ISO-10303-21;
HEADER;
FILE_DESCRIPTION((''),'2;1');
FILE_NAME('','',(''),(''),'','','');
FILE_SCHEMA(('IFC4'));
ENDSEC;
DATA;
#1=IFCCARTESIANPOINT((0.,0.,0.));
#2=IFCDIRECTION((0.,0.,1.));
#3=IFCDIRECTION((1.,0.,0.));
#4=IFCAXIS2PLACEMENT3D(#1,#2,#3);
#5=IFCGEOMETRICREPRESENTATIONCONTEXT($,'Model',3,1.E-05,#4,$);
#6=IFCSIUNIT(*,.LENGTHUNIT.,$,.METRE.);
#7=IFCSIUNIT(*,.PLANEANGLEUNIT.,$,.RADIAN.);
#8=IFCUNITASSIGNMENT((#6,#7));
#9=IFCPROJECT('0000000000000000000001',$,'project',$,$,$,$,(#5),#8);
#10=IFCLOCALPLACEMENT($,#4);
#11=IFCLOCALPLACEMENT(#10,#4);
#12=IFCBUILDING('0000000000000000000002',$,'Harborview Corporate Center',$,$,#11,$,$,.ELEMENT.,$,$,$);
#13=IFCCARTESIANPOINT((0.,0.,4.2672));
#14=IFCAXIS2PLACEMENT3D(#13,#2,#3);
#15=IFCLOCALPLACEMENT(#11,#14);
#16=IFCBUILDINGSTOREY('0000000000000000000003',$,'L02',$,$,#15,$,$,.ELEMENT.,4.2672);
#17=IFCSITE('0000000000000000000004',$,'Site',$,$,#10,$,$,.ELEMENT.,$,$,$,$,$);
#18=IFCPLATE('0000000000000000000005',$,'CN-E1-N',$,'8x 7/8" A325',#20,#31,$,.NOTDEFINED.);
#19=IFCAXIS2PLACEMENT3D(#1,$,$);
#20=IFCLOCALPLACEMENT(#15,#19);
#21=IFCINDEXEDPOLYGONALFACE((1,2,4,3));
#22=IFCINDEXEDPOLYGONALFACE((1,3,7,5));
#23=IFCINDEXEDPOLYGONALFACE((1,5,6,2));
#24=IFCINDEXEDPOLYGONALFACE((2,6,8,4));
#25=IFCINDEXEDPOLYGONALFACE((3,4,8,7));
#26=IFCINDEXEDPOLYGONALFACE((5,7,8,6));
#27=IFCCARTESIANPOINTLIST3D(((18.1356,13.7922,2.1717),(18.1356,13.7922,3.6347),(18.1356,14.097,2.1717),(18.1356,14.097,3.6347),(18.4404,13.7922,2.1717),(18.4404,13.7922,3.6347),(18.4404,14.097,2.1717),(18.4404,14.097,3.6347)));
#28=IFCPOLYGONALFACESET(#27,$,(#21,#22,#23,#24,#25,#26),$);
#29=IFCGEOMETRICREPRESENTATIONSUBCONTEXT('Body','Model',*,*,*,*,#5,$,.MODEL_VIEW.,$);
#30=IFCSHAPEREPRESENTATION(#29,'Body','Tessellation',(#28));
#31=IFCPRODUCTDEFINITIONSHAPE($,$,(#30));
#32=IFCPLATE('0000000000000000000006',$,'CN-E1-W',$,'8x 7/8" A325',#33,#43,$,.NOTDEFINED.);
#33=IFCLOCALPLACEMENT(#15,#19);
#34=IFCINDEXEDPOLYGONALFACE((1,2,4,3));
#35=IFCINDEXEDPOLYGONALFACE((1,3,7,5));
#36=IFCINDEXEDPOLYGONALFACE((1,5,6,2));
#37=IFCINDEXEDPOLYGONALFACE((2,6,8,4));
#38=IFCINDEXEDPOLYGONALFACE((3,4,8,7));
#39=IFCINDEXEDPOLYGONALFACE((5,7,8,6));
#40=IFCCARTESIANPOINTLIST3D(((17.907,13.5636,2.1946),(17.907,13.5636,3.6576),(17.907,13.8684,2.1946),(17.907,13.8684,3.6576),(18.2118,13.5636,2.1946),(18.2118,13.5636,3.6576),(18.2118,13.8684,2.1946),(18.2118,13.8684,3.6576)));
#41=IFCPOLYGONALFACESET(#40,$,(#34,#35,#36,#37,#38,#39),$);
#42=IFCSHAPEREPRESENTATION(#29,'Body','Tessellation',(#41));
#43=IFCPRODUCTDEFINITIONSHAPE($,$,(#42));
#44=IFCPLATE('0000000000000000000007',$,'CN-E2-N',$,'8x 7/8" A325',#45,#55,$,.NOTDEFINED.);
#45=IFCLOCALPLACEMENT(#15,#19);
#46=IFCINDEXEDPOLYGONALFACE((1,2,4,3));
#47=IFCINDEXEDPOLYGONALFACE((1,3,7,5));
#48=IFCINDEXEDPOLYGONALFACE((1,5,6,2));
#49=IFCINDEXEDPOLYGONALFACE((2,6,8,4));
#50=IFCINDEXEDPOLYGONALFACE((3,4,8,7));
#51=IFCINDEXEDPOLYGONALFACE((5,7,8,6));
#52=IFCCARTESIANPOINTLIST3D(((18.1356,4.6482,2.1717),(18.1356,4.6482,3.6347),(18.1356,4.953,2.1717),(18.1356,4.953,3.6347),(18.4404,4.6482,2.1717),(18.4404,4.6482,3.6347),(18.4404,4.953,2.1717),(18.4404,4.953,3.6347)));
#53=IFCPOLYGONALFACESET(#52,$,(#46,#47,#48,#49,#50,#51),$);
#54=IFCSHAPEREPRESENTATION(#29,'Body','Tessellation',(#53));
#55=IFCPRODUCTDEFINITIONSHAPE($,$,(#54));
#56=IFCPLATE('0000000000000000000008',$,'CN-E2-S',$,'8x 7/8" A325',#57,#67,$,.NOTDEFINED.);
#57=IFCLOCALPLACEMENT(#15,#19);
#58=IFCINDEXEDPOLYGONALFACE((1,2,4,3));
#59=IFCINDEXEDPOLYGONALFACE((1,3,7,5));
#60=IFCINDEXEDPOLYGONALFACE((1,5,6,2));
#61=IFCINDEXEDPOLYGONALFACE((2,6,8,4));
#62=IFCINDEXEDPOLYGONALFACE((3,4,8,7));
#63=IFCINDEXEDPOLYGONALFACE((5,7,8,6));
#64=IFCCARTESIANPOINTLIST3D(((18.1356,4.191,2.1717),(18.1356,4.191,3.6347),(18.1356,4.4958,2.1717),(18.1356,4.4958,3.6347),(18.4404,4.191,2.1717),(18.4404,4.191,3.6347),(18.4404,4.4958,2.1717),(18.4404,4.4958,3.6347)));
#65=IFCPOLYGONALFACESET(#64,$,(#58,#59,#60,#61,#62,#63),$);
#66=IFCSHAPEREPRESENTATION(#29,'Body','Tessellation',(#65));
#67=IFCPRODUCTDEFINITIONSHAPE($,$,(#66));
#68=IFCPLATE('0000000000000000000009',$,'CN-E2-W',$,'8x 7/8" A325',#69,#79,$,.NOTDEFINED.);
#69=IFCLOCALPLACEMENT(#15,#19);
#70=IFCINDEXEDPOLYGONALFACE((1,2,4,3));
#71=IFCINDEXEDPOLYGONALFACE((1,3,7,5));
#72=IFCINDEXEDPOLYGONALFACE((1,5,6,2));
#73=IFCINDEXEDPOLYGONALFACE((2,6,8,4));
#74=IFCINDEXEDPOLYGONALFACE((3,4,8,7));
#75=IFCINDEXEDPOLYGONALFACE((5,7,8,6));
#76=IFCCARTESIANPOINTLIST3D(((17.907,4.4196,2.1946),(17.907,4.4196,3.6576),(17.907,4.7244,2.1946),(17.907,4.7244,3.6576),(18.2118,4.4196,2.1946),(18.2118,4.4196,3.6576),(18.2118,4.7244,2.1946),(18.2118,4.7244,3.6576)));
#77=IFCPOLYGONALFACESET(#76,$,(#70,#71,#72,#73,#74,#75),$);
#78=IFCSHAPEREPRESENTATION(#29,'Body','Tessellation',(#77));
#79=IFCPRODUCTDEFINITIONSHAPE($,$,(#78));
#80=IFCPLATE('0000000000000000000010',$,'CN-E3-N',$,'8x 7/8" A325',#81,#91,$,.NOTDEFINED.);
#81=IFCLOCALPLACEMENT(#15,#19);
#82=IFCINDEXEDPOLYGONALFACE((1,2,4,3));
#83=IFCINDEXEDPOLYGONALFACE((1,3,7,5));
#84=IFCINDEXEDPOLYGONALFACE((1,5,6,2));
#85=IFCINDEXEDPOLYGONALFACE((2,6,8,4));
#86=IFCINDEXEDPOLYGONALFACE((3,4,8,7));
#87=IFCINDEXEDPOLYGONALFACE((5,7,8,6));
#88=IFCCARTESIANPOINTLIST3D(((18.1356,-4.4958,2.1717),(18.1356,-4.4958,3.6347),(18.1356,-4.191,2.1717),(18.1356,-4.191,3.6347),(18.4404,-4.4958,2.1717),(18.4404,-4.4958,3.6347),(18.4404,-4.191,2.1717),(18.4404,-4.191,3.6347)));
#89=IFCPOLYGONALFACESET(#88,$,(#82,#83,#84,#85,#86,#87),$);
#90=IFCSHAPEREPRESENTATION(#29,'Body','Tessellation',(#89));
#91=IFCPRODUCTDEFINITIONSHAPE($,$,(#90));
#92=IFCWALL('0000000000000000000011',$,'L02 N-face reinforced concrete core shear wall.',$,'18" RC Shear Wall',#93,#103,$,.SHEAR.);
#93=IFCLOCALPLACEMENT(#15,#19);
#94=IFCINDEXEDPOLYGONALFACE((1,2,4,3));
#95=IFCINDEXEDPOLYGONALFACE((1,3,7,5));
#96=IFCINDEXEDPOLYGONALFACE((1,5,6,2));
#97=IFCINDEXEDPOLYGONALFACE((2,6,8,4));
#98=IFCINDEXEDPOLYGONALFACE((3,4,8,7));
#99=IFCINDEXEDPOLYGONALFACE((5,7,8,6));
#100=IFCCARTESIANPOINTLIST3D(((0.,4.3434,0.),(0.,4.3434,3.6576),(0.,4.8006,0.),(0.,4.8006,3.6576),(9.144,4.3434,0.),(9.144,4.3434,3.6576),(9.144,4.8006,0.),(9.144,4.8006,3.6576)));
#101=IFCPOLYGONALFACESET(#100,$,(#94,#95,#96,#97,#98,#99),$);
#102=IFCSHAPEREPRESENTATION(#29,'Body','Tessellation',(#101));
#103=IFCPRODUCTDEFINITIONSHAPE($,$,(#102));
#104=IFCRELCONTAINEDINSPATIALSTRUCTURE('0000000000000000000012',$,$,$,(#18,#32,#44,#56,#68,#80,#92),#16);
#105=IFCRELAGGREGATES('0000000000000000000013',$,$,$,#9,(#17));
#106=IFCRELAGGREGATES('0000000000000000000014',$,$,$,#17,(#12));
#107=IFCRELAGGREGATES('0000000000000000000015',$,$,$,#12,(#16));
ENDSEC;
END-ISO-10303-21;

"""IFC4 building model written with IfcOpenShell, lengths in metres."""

from ifc_helpers import new_model, si_unit, frame, origin_with_axes, place, context, subcontext, project, spatial, rectangle, extrude, element, save


model = new_model("IFC4")

# Units and contexts
model_context = context("Model", 3, precision=1e-05, world=origin_with_axes())
body_context = subcontext(model_context, "Body", "Model", "MODEL_VIEW")
ifc_project = project(units=[si_unit("LENGTHUNIT", "METRE"), si_unit("PLANEANGLEUNIT", "RADIAN")], contexts=[model_context])

# Site, building, storey
site_placement = place(None, origin_with_axes())
site = spatial("IfcSite", under=ifc_project, at=site_placement, Name="Site", CompositionType="ELEMENT")
building_placement = place(site_placement, origin_with_axes())
building = spatial("IfcBuilding", under=site, at=building_placement, Name="Harborview Corporate Center", CompositionType="ELEMENT")
storey_placement = place(building_placement, frame((0.0, 0.0, 4.2672), z_axis=(0.0, 0.0, 1.0), x_axis=(1.0, 0.0, 0.0)))
storey = spatial("IfcBuildingStorey", under=building, at=storey_placement, Name="L02", CompositionType="ELEMENT", Elevation=4.2672)

# Plates
for number, where, z_axis, x_axis, name in (
    (1, (18.288, 13.9446, 2.1717), (0.0, 0.0, 1.0), (1.0, 0.0, 0.0), "CN-E1-N"),
    (2, (18.0594, 13.716, 2.1946), (0.0, 0.0, 1.0), (1.0, 0.0, 0.0), "CN-E1-W"),
    (3, (18.288, 4.8006, 2.1717), (0.0, 0.0, 1.0), (1.0, 0.0, 0.0), "CN-E2-N"),
    (4, (18.288, 4.3434, 2.1717), (0.0, 0.0, 1.0), (1.0, 0.0, 0.0), "CN-E2-S"),
    (5, (18.0594, 4.572, 2.1946), (0.0, 0.0, 1.0), (1.0, 0.0, 0.0), "CN-E2-W"),
    (6, (18.288, -4.3434, 2.1717), (0.0, 0.0, 1.0), (1.0, 0.0, 0.0), "CN-E3-N"),
):
    element("IfcPlate", number, at=place(storey_placement, frame(where, z_axis=z_axis, x_axis=x_axis)), inside=storey, Name=name, ObjectType="8x 7/8\" A325", PredefinedType="NOTDEFINED", context=body_context, shape_type="SweptSolid", body=[
        extrude(rectangle(XDim=0.3048, YDim=0.3048), origin_with_axes(), (0.0, 0.0, 1.0), 1.463),
    ])

# Wall
wall_placement = place(storey_placement, frame((4.572, 4.572, 0.0), z_axis=(0.0, 0.0, 1.0), x_axis=(1.0, 0.0, 0.0)))
element("IfcWall", 7, at=wall_placement, inside=storey, Name="L02 N-face reinforced concrete core shear wall.", ObjectType="18\" RC Shear Wall", PredefinedType="SHEAR", context=body_context, shape_type="SweptSolid", body=[
    extrude(rectangle(XDim=9.144, YDim=0.4572), origin_with_axes(), (0.0, 0.0, 1.0), 3.6576),
])

save(model, "model.ifc")
